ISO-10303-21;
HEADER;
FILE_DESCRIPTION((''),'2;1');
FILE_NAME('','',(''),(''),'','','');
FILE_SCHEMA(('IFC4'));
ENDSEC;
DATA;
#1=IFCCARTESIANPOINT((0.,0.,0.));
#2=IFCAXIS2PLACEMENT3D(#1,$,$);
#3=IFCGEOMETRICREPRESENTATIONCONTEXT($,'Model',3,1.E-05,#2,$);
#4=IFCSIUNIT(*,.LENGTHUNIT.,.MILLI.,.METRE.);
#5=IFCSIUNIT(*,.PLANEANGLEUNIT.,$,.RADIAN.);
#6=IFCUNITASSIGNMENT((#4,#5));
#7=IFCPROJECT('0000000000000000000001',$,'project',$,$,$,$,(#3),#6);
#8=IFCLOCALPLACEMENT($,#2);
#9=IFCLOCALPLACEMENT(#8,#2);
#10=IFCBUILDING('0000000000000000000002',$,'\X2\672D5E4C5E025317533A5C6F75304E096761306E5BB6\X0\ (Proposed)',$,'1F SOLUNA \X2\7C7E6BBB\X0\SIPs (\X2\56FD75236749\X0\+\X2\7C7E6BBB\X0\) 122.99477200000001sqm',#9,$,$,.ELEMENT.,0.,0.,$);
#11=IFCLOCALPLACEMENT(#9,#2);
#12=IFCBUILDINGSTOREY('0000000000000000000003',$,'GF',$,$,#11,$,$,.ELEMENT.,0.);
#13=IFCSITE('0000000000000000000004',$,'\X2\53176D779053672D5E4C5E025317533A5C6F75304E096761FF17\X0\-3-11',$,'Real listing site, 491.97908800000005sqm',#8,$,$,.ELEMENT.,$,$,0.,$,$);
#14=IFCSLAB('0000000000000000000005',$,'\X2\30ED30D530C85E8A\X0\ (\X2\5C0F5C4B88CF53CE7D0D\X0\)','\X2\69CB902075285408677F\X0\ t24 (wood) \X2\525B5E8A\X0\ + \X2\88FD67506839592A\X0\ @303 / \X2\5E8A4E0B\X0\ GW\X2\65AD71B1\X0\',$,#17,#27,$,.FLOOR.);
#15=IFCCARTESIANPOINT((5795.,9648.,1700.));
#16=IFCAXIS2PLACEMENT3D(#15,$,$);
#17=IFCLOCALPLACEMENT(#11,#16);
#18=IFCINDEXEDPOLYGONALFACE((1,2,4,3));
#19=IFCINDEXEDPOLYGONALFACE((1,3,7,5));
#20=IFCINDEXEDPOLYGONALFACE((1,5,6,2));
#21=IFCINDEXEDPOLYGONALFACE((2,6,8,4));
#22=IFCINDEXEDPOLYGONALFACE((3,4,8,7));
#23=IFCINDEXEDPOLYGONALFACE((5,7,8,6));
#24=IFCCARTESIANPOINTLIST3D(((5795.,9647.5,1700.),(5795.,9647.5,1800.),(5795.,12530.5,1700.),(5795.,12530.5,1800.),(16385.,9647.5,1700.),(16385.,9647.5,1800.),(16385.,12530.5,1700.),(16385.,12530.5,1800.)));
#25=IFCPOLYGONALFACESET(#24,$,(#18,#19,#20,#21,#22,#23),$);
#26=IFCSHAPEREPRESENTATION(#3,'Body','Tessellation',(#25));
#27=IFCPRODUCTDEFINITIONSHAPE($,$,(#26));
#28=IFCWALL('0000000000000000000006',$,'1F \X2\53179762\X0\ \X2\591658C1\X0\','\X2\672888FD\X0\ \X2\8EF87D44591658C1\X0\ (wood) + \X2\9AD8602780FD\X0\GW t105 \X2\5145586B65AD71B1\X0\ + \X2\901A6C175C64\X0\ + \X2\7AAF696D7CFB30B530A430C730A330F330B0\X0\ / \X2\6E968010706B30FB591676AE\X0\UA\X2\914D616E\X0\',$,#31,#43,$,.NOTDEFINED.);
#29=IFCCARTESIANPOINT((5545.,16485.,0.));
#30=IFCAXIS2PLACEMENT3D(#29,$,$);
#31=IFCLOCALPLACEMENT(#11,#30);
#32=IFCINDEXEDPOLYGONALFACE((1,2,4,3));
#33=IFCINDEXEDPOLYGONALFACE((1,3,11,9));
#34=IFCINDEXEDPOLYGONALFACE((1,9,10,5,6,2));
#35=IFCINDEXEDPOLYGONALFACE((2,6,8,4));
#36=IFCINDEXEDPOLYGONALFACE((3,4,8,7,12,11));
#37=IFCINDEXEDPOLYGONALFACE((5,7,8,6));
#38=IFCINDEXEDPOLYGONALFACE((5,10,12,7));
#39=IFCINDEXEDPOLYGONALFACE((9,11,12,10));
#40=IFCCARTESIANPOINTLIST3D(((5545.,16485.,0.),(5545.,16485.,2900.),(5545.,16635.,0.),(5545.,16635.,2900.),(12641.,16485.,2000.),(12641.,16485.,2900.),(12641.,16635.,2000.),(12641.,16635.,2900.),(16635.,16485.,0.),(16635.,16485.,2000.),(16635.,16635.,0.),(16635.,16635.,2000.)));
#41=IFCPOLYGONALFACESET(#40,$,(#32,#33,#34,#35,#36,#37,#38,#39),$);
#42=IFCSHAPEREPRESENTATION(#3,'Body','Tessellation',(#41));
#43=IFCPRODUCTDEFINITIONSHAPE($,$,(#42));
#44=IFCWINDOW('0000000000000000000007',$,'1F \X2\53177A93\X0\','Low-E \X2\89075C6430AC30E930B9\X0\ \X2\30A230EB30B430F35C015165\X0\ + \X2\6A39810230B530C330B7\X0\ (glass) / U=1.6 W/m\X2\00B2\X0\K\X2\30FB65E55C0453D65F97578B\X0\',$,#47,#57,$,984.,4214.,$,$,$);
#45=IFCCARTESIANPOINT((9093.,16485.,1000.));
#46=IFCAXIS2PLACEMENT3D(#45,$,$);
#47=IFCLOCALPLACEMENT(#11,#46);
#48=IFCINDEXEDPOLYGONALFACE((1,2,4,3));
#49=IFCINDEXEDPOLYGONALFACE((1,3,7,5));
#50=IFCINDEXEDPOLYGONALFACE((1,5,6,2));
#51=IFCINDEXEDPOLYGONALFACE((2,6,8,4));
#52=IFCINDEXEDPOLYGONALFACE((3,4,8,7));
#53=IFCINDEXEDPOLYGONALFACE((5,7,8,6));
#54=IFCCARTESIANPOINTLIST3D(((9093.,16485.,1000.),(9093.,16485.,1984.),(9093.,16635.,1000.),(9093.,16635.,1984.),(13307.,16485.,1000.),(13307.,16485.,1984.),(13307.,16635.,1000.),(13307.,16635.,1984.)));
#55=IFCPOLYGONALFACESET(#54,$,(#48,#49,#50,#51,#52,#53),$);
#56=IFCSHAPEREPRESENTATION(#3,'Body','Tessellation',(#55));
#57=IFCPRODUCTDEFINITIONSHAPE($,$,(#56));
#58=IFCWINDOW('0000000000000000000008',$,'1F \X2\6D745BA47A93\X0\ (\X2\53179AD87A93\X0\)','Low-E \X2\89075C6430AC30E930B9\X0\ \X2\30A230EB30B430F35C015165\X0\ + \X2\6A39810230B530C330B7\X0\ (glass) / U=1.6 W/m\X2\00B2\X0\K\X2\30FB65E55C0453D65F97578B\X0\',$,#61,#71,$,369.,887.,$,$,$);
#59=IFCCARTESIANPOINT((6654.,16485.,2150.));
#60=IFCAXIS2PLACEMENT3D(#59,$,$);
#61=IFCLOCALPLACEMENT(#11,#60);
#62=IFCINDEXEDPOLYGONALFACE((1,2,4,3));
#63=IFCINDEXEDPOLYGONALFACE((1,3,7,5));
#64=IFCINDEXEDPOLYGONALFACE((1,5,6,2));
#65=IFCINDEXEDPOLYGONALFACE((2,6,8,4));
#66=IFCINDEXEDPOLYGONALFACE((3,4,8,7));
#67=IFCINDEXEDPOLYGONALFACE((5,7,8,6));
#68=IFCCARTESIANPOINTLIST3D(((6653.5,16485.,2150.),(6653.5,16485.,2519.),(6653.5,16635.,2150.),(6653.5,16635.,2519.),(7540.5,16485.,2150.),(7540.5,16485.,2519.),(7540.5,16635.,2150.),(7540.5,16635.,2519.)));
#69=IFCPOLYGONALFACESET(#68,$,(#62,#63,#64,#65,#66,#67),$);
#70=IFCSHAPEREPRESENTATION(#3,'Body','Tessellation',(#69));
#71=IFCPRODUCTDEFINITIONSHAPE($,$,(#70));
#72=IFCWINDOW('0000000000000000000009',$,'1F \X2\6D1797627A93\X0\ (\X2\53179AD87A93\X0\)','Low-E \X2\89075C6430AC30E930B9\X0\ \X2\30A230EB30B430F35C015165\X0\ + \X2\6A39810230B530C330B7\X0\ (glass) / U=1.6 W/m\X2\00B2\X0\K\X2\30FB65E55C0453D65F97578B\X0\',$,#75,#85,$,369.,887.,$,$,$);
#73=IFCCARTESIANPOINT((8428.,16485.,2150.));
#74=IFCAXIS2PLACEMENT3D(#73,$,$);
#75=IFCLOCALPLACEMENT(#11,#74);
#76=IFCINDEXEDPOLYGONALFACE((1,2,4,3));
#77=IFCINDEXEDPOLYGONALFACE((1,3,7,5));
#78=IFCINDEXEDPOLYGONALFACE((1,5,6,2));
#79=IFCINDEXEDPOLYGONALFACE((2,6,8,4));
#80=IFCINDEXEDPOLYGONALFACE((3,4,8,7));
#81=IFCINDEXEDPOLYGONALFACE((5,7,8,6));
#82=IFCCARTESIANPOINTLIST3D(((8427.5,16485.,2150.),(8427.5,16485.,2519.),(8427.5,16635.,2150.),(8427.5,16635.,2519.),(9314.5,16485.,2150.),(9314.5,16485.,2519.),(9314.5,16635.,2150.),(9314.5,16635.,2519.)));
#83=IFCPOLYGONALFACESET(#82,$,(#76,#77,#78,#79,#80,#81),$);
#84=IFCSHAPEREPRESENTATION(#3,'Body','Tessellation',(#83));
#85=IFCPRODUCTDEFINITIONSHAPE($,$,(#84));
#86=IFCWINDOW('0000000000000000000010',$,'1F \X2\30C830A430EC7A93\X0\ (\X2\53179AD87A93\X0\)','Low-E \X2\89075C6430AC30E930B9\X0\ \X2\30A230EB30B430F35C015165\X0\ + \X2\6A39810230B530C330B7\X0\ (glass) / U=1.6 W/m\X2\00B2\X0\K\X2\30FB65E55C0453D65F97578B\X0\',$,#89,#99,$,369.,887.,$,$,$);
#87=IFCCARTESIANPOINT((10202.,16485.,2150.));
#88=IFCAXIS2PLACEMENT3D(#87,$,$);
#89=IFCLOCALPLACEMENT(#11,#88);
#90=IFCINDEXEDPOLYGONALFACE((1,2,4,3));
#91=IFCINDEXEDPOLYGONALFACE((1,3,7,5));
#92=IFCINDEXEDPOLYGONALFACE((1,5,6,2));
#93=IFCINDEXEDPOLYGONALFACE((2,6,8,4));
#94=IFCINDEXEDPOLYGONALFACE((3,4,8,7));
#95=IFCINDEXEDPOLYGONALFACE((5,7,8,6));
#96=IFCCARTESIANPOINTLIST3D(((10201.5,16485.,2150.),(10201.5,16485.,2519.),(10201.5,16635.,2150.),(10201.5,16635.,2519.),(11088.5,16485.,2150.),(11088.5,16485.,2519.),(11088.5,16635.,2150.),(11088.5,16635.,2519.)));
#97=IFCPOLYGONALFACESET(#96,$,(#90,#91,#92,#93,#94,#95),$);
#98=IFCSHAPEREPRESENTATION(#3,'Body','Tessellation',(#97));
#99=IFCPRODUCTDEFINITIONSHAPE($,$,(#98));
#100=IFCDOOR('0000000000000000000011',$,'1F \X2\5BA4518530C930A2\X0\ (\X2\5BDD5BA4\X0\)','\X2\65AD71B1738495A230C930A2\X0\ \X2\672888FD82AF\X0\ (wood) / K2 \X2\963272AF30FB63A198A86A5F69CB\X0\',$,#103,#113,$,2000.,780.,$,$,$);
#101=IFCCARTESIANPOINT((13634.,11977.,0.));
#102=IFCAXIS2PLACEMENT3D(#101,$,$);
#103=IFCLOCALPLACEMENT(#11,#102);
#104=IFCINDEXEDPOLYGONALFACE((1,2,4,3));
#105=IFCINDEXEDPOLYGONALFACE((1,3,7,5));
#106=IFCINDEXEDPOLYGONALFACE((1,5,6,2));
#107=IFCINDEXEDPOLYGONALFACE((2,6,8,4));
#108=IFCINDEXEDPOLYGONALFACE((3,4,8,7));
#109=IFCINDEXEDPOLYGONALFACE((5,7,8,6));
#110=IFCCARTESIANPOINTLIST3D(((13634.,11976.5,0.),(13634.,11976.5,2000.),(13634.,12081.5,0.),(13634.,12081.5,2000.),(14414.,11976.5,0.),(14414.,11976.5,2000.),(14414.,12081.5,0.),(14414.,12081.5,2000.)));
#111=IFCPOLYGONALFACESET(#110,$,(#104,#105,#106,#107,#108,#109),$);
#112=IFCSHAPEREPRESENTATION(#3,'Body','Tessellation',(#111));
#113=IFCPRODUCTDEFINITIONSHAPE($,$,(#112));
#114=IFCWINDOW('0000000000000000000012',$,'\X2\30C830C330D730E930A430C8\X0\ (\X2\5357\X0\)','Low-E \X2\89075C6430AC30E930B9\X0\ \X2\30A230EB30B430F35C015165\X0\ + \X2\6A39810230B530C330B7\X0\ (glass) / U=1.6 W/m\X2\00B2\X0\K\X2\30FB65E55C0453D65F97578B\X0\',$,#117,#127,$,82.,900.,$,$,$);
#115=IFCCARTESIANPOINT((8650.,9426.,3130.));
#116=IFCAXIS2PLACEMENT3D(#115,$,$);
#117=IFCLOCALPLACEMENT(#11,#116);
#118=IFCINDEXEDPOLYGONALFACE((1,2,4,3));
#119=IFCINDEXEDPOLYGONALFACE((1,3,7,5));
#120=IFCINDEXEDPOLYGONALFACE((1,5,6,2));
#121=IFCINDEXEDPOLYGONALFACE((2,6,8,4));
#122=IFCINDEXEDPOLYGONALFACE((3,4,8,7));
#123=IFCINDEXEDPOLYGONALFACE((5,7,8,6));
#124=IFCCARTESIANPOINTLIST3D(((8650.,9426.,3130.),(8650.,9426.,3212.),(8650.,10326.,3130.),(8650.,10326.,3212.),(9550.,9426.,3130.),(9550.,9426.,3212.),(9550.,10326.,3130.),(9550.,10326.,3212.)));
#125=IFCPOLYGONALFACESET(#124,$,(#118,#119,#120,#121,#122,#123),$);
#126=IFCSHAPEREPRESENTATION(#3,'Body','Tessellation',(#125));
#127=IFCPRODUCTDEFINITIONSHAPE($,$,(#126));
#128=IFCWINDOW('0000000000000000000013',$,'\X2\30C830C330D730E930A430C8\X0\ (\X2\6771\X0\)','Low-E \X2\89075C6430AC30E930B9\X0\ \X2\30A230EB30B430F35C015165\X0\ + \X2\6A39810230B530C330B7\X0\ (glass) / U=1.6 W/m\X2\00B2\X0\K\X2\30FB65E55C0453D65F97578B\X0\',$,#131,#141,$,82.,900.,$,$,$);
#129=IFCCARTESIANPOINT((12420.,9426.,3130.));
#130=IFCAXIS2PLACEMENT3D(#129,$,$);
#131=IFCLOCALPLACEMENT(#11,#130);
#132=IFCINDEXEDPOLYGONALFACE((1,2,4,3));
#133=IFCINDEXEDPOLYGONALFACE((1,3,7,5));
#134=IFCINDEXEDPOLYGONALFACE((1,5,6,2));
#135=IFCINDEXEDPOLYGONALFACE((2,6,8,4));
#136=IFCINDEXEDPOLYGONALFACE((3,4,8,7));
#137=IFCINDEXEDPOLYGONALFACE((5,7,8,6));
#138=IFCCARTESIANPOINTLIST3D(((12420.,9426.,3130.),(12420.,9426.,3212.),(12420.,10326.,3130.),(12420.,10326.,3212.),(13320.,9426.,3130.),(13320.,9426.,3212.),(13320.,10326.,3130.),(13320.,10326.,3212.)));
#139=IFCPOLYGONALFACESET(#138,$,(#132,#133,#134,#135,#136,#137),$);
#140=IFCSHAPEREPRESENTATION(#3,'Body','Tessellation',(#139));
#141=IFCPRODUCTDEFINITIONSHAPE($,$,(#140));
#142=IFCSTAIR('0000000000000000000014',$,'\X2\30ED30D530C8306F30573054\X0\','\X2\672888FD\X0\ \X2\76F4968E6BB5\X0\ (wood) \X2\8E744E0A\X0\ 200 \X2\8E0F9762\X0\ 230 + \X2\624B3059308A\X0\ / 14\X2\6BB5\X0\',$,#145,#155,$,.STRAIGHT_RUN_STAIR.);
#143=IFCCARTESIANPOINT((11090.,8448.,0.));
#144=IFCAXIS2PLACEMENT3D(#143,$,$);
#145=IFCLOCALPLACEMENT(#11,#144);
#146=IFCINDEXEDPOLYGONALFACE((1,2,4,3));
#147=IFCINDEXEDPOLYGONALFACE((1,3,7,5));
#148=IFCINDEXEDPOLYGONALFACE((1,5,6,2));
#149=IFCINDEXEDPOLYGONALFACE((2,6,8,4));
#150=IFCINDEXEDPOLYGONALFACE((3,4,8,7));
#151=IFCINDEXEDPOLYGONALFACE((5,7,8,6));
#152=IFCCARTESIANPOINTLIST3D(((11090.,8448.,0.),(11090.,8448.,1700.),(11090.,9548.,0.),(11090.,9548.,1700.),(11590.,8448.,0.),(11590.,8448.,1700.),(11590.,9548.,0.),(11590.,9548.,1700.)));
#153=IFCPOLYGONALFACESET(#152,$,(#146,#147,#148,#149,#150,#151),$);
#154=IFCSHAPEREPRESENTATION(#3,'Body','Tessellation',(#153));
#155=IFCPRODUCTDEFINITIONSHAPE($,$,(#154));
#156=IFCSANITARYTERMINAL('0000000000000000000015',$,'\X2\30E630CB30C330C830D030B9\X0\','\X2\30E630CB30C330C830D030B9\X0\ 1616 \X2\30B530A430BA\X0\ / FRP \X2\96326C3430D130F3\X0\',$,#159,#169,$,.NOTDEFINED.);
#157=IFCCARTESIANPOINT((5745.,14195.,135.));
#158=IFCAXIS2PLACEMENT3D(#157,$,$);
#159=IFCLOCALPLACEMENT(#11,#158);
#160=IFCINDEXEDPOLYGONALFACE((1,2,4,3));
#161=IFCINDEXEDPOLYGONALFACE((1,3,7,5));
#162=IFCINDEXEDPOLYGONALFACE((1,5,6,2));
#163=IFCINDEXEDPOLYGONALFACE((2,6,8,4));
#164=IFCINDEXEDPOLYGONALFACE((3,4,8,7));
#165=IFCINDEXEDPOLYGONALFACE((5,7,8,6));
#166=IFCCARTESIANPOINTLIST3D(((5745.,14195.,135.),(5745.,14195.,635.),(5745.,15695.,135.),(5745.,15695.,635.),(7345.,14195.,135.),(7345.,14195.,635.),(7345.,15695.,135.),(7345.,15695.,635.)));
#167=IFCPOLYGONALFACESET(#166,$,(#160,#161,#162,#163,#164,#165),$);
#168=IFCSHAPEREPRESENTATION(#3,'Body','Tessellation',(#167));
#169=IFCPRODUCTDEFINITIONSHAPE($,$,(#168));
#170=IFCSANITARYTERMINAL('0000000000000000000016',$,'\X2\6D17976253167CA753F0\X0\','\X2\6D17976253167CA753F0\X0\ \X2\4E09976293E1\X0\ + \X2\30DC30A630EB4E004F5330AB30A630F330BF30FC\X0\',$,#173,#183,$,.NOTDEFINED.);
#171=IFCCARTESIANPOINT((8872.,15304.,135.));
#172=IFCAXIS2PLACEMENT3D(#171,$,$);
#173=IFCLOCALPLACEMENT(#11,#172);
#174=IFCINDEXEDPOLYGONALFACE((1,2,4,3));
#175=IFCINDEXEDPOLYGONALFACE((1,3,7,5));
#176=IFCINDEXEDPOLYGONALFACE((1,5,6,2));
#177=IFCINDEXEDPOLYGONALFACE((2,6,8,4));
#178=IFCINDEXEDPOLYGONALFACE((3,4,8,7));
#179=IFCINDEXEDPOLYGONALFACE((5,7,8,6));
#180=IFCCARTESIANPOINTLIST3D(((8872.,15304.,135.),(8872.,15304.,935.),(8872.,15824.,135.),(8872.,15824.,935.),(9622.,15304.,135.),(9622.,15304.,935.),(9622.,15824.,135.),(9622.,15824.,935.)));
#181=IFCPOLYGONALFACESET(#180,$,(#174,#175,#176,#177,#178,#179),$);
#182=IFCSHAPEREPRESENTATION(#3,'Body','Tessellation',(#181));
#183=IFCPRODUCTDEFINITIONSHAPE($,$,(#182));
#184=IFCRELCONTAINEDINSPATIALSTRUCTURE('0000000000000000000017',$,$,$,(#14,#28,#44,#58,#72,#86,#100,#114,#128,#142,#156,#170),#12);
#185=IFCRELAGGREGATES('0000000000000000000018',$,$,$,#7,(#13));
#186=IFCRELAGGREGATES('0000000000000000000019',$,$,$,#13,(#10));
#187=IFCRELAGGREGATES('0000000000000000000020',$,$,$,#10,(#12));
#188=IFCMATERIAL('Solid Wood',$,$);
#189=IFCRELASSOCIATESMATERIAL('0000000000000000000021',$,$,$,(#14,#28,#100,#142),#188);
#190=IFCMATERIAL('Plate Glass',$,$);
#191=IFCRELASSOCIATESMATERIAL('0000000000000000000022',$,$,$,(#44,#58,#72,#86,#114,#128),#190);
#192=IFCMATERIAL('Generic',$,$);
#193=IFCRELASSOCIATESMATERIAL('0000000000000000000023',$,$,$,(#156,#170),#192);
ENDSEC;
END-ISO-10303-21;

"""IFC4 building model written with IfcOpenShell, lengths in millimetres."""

from ifc_helpers import new_model, si_unit, frame, frame_2d, origin, place, context, project, spatial, rectangle, extrude, material, element, fill, save


model = new_model("IFC4")

# Units and contexts
model_context = context("Model", 3, precision=1e-05, world=origin())
ifc_project = project(units=[si_unit("LENGTHUNIT", "METRE", prefix="MILLI"), si_unit("PLANEANGLEUNIT", "RADIAN")], contexts=[model_context])

# Site, building, storey
site_placement = place(None, origin())
site = spatial("IfcSite", under=ifc_project, at=site_placement, Name="北海道札幌市北区屯田三条７-3-11", ObjectType="Real listing site, 491.97908800000005sqm", CompositionType="ELEMENT", RefElevation=0.0)
building_placement = place(site_placement, origin())
building = spatial("IfcBuilding", under=site, at=building_placement, Name="札幌市北区屯田三条の家 (Proposed)", ObjectType="1F SOLUNA 籾殻SIPs (国産杉+籾殻) 122.99477200000001sqm", CompositionType="ELEMENT", ElevationOfRefHeight=0.0, ElevationOfTerrain=0.0)
storey_placement = place(building_placement, origin())
storey = spatial("IfcBuildingStorey", under=building, at=storey_placement, Name="GF", CompositionType="ELEMENT", Elevation=0.0)

# Slab
ifc_material_1 = material(Name="Solid Wood")
slab_placement = place(storey_placement, frame((5795.0, 9648.0, 1700.0)))
element("IfcSlab", 1, at=slab_placement, inside=storey, material=ifc_material_1, Name="ロフト床 (小屋裏収納)", Description="構造用合板 t24 (wood) 剛床 + 製材根太 @303 / 床下 GW断熱", PredefinedType="FLOOR", context=model_context, shape_type="SweptSolid", body=[
    extrude(rectangle(XDim=10590.0, YDim=2883.0, at=frame_2d((5295.0, 1441.0))), frame((5795.0, 9648.0, 1700.0)), (0.0, 0.0, 1.0), 100.0),
])

# Wall, openings, windows
wall_1_placement = place(storey_placement, frame((5545.0, 16485.0, 0.0)))
wall_1 = element("IfcWall", 2, at=wall_1_placement, inside=storey, material=ifc_material_1, Name="1F 北面 外壁", Description="木製 軸組外壁 (wood) + 高性能GW t105 充填断熱 + 通気層 + 窯業系サイディング / 準耐火・外皮UA配慮", PredefinedType="NOTDEFINED", context=model_context, shape_type="SweptSolid", body=[
    extrude(rectangle(XDim=11090.0, YDim=150.0, at=frame_2d((5545.0, 75.0))), frame((5545.0, 16485.0, 0.0)), (0.0, 0.0, 1.0), 2900.0),
])
opening_1_placement = place(storey_placement, frame((9093.0, 16485.0, 1000.0)))
opening_1 = element("IfcOpeningElement", 3, at=opening_1_placement, cuts=wall_1, PredefinedType="NOTDEFINED", context=model_context, shape_type="SweptSolid", body=[
    extrude(rectangle(XDim=4214.0, YDim=150.0, at=frame_2d((2107.0, 75.0))), frame((9093.0, 16485.0, 1000.0)), (0.0, 0.0, 1.0), 984.0),
])
opening_2_placement = place(storey_placement, frame((6654.0, 16485.0, 2150.0)))
opening_2 = element("IfcOpeningElement", 4, at=opening_2_placement, cuts=wall_1, PredefinedType="NOTDEFINED", context=model_context, shape_type="SweptSolid", body=[
    extrude(rectangle(XDim=887.0, YDim=150.0, at=frame_2d((443.0, 75.0))), frame((6654.0, 16485.0, 2150.0)), (0.0, 0.0, 1.0), 369.0),
])
opening_3_placement = place(storey_placement, frame((8428.0, 16485.0, 2150.0)))
opening_3 = element("IfcOpeningElement", 5, at=opening_3_placement, cuts=wall_1, PredefinedType="NOTDEFINED", context=model_context, shape_type="SweptSolid", body=[
    extrude(rectangle(XDim=887.0, YDim=150.0, at=frame_2d((443.0, 75.0))), frame((8428.0, 16485.0, 2150.0)), (0.0, 0.0, 1.0), 369.0),
])
opening_4_placement = place(storey_placement, frame((10202.0, 16485.0, 2150.0)))
opening_4 = element("IfcOpeningElement", 6, at=opening_4_placement, cuts=wall_1, PredefinedType="NOTDEFINED", context=model_context, shape_type="SweptSolid", body=[
    extrude(rectangle(XDim=887.0, YDim=150.0, at=frame_2d((443.0, 75.0))), frame((10202.0, 16485.0, 2150.0)), (0.0, 0.0, 1.0), 369.0),
])
ifc_material_2 = material(Name="Plate Glass")
window_1_placement = place(storey_placement, frame((9093.0, 16485.0, 1000.0)))
window_1 = element("IfcWindow", 7, at=window_1_placement, inside=storey, material=ifc_material_2, Name="1F 北窓", Description="Low-E 複層ガラス アルゴン封入 + 樹脂サッシ (glass) / U=1.6 W/m²K・日射取得型", OverallHeight=984.0, OverallWidth=4214.0, context=model_context, shape_type="SweptSolid", body=[
    extrude(rectangle(XDim=4214.0, YDim=150.0, at=frame_2d((2107.0, 75.0))), frame((9093.0, 16485.0, 1000.0)), (0.0, 0.0, 1.0), 984.0),
])
fill(opening_1, window_1)
window_2_placement = place(storey_placement, frame((6654.0, 16485.0, 2150.0)))
window_2 = element("IfcWindow", 8, at=window_2_placement, inside=storey, material=ifc_material_2, Name="1F 浴室窓 (北高窓)", Description="Low-E 複層ガラス アルゴン封入 + 樹脂サッシ (glass) / U=1.6 W/m²K・日射取得型", OverallHeight=369.0, OverallWidth=887.0, context=model_context, shape_type="SweptSolid", body=[
    extrude(rectangle(XDim=887.0, YDim=150.0, at=frame_2d((443.0, 75.0))), frame((6654.0, 16485.0, 2150.0)), (0.0, 0.0, 1.0), 369.0),
])
fill(opening_2, window_2)
window_3_placement = place(storey_placement, frame((8428.0, 16485.0, 2150.0)))
window_3 = element("IfcWindow", 9, at=window_3_placement, inside=storey, material=ifc_material_2, Name="1F 洗面窓 (北高窓)", Description="Low-E 複層ガラス アルゴン封入 + 樹脂サッシ (glass) / U=1.6 W/m²K・日射取得型", OverallHeight=369.0, OverallWidth=887.0, context=model_context, shape_type="SweptSolid", body=[
    extrude(rectangle(XDim=887.0, YDim=150.0, at=frame_2d((443.0, 75.0))), frame((8428.0, 16485.0, 2150.0)), (0.0, 0.0, 1.0), 369.0),
])
fill(opening_3, window_3)
window_4_placement = place(storey_placement, frame((10202.0, 16485.0, 2150.0)))
window_4 = element("IfcWindow", 10, at=window_4_placement, inside=storey, material=ifc_material_2, Name="1F トイレ窓 (北高窓)", Description="Low-E 複層ガラス アルゴン封入 + 樹脂サッシ (glass) / U=1.6 W/m²K・日射取得型", OverallHeight=369.0, OverallWidth=887.0, context=model_context, shape_type="SweptSolid", body=[
    extrude(rectangle(XDim=887.0, YDim=150.0, at=frame_2d((443.0, 75.0))), frame((10202.0, 16485.0, 2150.0)), (0.0, 0.0, 1.0), 369.0),
])
fill(opening_4, window_4)

# Door
door_1_placement = place(storey_placement, frame((13634.0, 11977.0, 0.0)))
element("IfcDoor", 11, at=door_1_placement, inside=storey, material=ifc_material_1, Name="1F 室内ドア (寝室)", Description="断熱玄関ドア 木製芯 (wood) / K2 防犯・採風機構", OverallHeight=2000.0, OverallWidth=780.0, context=model_context, shape_type="SweptSolid", body=[
    extrude(rectangle(XDim=780.0, YDim=105.0, at=frame_2d((390.0, 52.0))), frame((13634.0, 11977.0, 0.0)), (0.0, 0.0, 1.0), 2000.0),
])

# Windows
window_5_placement = place(storey_placement, frame((8650.0, 9426.0, 3130.0)))
element("IfcWindow", 12, at=window_5_placement, inside=storey, material=ifc_material_2, Name="トップライト (南)", Description="Low-E 複層ガラス アルゴン封入 + 樹脂サッシ (glass) / U=1.6 W/m²K・日射取得型", OverallHeight=82.0, OverallWidth=900.0, context=model_context, shape_type="SweptSolid", body=[
    extrude(rectangle(XDim=900.0, YDim=900.0, at=frame_2d((450.0, 450.0))), frame((8650.0, 9426.0, 3130.0)), (0.0, 0.0, 1.0), 82.0),
])
window_6_placement = place(storey_placement, frame((12420.0, 9426.0, 3130.0)))
element("IfcWindow", 13, at=window_6_placement, inside=storey, material=ifc_material_2, Name="トップライト (東)", Description="Low-E 複層ガラス アルゴン封入 + 樹脂サッシ (glass) / U=1.6 W/m²K・日射取得型", OverallHeight=82.0, OverallWidth=900.0, context=model_context, shape_type="SweptSolid", body=[
    extrude(rectangle(XDim=900.0, YDim=900.0, at=frame_2d((450.0, 450.0))), frame((12420.0, 9426.0, 3130.0)), (0.0, 0.0, 1.0), 82.0),
])

# Stair
stair_placement = place(storey_placement, frame((11090.0, 8448.0, 0.0)))
element("IfcStair", 14, at=stair_placement, inside=storey, material=ifc_material_1, Name="ロフトはしご", Description="木製 直階段 (wood) 蹴上 200 踏面 230 + 手すり / 14段", PredefinedType="STRAIGHT_RUN_STAIR", context=model_context, shape_type="SweptSolid", body=[
    extrude(rectangle(XDim=500.0, YDim=1100.0, at=frame_2d((250.0, 550.0))), frame((11090.0, 8448.0, 0.0)), (0.0, 0.0, 1.0), 1700.0),
])

# Sanitary terminals
ifc_material_3 = material(Name="Generic")
sanitary_terminal_1_placement = place(storey_placement, frame((5745.0, 14195.0, 135.0)))
element("IfcSanitaryTerminal", 15, at=sanitary_terminal_1_placement, inside=storey, material=ifc_material_3, Name="ユニットバス", Description="ユニットバス 1616 サイズ / FRP 防水パン", PredefinedType="NOTDEFINED", context=model_context, shape_type="SweptSolid", body=[
    extrude(rectangle(XDim=1600.0, YDim=1500.0, at=frame_2d((800.0, 750.0))), frame((5745.0, 14195.0, 135.0)), (0.0, 0.0, 1.0), 500.0),
])
sanitary_terminal_2_placement = place(storey_placement, frame((8872.0, 15304.0, 135.0)))
element("IfcSanitaryTerminal", 16, at=sanitary_terminal_2_placement, inside=storey, material=ifc_material_3, Name="洗面化粧台", Description="洗面化粧台 三面鏡 + ボウル一体カウンター", PredefinedType="NOTDEFINED", context=model_context, shape_type="SweptSolid", body=[
    extrude(rectangle(XDim=750.0, YDim=520.0, at=frame_2d((375.0, 260.0))), frame((8872.0, 15304.0, 135.0)), (0.0, 0.0, 1.0), 800.0),
])

save(model, "model.ifc")
